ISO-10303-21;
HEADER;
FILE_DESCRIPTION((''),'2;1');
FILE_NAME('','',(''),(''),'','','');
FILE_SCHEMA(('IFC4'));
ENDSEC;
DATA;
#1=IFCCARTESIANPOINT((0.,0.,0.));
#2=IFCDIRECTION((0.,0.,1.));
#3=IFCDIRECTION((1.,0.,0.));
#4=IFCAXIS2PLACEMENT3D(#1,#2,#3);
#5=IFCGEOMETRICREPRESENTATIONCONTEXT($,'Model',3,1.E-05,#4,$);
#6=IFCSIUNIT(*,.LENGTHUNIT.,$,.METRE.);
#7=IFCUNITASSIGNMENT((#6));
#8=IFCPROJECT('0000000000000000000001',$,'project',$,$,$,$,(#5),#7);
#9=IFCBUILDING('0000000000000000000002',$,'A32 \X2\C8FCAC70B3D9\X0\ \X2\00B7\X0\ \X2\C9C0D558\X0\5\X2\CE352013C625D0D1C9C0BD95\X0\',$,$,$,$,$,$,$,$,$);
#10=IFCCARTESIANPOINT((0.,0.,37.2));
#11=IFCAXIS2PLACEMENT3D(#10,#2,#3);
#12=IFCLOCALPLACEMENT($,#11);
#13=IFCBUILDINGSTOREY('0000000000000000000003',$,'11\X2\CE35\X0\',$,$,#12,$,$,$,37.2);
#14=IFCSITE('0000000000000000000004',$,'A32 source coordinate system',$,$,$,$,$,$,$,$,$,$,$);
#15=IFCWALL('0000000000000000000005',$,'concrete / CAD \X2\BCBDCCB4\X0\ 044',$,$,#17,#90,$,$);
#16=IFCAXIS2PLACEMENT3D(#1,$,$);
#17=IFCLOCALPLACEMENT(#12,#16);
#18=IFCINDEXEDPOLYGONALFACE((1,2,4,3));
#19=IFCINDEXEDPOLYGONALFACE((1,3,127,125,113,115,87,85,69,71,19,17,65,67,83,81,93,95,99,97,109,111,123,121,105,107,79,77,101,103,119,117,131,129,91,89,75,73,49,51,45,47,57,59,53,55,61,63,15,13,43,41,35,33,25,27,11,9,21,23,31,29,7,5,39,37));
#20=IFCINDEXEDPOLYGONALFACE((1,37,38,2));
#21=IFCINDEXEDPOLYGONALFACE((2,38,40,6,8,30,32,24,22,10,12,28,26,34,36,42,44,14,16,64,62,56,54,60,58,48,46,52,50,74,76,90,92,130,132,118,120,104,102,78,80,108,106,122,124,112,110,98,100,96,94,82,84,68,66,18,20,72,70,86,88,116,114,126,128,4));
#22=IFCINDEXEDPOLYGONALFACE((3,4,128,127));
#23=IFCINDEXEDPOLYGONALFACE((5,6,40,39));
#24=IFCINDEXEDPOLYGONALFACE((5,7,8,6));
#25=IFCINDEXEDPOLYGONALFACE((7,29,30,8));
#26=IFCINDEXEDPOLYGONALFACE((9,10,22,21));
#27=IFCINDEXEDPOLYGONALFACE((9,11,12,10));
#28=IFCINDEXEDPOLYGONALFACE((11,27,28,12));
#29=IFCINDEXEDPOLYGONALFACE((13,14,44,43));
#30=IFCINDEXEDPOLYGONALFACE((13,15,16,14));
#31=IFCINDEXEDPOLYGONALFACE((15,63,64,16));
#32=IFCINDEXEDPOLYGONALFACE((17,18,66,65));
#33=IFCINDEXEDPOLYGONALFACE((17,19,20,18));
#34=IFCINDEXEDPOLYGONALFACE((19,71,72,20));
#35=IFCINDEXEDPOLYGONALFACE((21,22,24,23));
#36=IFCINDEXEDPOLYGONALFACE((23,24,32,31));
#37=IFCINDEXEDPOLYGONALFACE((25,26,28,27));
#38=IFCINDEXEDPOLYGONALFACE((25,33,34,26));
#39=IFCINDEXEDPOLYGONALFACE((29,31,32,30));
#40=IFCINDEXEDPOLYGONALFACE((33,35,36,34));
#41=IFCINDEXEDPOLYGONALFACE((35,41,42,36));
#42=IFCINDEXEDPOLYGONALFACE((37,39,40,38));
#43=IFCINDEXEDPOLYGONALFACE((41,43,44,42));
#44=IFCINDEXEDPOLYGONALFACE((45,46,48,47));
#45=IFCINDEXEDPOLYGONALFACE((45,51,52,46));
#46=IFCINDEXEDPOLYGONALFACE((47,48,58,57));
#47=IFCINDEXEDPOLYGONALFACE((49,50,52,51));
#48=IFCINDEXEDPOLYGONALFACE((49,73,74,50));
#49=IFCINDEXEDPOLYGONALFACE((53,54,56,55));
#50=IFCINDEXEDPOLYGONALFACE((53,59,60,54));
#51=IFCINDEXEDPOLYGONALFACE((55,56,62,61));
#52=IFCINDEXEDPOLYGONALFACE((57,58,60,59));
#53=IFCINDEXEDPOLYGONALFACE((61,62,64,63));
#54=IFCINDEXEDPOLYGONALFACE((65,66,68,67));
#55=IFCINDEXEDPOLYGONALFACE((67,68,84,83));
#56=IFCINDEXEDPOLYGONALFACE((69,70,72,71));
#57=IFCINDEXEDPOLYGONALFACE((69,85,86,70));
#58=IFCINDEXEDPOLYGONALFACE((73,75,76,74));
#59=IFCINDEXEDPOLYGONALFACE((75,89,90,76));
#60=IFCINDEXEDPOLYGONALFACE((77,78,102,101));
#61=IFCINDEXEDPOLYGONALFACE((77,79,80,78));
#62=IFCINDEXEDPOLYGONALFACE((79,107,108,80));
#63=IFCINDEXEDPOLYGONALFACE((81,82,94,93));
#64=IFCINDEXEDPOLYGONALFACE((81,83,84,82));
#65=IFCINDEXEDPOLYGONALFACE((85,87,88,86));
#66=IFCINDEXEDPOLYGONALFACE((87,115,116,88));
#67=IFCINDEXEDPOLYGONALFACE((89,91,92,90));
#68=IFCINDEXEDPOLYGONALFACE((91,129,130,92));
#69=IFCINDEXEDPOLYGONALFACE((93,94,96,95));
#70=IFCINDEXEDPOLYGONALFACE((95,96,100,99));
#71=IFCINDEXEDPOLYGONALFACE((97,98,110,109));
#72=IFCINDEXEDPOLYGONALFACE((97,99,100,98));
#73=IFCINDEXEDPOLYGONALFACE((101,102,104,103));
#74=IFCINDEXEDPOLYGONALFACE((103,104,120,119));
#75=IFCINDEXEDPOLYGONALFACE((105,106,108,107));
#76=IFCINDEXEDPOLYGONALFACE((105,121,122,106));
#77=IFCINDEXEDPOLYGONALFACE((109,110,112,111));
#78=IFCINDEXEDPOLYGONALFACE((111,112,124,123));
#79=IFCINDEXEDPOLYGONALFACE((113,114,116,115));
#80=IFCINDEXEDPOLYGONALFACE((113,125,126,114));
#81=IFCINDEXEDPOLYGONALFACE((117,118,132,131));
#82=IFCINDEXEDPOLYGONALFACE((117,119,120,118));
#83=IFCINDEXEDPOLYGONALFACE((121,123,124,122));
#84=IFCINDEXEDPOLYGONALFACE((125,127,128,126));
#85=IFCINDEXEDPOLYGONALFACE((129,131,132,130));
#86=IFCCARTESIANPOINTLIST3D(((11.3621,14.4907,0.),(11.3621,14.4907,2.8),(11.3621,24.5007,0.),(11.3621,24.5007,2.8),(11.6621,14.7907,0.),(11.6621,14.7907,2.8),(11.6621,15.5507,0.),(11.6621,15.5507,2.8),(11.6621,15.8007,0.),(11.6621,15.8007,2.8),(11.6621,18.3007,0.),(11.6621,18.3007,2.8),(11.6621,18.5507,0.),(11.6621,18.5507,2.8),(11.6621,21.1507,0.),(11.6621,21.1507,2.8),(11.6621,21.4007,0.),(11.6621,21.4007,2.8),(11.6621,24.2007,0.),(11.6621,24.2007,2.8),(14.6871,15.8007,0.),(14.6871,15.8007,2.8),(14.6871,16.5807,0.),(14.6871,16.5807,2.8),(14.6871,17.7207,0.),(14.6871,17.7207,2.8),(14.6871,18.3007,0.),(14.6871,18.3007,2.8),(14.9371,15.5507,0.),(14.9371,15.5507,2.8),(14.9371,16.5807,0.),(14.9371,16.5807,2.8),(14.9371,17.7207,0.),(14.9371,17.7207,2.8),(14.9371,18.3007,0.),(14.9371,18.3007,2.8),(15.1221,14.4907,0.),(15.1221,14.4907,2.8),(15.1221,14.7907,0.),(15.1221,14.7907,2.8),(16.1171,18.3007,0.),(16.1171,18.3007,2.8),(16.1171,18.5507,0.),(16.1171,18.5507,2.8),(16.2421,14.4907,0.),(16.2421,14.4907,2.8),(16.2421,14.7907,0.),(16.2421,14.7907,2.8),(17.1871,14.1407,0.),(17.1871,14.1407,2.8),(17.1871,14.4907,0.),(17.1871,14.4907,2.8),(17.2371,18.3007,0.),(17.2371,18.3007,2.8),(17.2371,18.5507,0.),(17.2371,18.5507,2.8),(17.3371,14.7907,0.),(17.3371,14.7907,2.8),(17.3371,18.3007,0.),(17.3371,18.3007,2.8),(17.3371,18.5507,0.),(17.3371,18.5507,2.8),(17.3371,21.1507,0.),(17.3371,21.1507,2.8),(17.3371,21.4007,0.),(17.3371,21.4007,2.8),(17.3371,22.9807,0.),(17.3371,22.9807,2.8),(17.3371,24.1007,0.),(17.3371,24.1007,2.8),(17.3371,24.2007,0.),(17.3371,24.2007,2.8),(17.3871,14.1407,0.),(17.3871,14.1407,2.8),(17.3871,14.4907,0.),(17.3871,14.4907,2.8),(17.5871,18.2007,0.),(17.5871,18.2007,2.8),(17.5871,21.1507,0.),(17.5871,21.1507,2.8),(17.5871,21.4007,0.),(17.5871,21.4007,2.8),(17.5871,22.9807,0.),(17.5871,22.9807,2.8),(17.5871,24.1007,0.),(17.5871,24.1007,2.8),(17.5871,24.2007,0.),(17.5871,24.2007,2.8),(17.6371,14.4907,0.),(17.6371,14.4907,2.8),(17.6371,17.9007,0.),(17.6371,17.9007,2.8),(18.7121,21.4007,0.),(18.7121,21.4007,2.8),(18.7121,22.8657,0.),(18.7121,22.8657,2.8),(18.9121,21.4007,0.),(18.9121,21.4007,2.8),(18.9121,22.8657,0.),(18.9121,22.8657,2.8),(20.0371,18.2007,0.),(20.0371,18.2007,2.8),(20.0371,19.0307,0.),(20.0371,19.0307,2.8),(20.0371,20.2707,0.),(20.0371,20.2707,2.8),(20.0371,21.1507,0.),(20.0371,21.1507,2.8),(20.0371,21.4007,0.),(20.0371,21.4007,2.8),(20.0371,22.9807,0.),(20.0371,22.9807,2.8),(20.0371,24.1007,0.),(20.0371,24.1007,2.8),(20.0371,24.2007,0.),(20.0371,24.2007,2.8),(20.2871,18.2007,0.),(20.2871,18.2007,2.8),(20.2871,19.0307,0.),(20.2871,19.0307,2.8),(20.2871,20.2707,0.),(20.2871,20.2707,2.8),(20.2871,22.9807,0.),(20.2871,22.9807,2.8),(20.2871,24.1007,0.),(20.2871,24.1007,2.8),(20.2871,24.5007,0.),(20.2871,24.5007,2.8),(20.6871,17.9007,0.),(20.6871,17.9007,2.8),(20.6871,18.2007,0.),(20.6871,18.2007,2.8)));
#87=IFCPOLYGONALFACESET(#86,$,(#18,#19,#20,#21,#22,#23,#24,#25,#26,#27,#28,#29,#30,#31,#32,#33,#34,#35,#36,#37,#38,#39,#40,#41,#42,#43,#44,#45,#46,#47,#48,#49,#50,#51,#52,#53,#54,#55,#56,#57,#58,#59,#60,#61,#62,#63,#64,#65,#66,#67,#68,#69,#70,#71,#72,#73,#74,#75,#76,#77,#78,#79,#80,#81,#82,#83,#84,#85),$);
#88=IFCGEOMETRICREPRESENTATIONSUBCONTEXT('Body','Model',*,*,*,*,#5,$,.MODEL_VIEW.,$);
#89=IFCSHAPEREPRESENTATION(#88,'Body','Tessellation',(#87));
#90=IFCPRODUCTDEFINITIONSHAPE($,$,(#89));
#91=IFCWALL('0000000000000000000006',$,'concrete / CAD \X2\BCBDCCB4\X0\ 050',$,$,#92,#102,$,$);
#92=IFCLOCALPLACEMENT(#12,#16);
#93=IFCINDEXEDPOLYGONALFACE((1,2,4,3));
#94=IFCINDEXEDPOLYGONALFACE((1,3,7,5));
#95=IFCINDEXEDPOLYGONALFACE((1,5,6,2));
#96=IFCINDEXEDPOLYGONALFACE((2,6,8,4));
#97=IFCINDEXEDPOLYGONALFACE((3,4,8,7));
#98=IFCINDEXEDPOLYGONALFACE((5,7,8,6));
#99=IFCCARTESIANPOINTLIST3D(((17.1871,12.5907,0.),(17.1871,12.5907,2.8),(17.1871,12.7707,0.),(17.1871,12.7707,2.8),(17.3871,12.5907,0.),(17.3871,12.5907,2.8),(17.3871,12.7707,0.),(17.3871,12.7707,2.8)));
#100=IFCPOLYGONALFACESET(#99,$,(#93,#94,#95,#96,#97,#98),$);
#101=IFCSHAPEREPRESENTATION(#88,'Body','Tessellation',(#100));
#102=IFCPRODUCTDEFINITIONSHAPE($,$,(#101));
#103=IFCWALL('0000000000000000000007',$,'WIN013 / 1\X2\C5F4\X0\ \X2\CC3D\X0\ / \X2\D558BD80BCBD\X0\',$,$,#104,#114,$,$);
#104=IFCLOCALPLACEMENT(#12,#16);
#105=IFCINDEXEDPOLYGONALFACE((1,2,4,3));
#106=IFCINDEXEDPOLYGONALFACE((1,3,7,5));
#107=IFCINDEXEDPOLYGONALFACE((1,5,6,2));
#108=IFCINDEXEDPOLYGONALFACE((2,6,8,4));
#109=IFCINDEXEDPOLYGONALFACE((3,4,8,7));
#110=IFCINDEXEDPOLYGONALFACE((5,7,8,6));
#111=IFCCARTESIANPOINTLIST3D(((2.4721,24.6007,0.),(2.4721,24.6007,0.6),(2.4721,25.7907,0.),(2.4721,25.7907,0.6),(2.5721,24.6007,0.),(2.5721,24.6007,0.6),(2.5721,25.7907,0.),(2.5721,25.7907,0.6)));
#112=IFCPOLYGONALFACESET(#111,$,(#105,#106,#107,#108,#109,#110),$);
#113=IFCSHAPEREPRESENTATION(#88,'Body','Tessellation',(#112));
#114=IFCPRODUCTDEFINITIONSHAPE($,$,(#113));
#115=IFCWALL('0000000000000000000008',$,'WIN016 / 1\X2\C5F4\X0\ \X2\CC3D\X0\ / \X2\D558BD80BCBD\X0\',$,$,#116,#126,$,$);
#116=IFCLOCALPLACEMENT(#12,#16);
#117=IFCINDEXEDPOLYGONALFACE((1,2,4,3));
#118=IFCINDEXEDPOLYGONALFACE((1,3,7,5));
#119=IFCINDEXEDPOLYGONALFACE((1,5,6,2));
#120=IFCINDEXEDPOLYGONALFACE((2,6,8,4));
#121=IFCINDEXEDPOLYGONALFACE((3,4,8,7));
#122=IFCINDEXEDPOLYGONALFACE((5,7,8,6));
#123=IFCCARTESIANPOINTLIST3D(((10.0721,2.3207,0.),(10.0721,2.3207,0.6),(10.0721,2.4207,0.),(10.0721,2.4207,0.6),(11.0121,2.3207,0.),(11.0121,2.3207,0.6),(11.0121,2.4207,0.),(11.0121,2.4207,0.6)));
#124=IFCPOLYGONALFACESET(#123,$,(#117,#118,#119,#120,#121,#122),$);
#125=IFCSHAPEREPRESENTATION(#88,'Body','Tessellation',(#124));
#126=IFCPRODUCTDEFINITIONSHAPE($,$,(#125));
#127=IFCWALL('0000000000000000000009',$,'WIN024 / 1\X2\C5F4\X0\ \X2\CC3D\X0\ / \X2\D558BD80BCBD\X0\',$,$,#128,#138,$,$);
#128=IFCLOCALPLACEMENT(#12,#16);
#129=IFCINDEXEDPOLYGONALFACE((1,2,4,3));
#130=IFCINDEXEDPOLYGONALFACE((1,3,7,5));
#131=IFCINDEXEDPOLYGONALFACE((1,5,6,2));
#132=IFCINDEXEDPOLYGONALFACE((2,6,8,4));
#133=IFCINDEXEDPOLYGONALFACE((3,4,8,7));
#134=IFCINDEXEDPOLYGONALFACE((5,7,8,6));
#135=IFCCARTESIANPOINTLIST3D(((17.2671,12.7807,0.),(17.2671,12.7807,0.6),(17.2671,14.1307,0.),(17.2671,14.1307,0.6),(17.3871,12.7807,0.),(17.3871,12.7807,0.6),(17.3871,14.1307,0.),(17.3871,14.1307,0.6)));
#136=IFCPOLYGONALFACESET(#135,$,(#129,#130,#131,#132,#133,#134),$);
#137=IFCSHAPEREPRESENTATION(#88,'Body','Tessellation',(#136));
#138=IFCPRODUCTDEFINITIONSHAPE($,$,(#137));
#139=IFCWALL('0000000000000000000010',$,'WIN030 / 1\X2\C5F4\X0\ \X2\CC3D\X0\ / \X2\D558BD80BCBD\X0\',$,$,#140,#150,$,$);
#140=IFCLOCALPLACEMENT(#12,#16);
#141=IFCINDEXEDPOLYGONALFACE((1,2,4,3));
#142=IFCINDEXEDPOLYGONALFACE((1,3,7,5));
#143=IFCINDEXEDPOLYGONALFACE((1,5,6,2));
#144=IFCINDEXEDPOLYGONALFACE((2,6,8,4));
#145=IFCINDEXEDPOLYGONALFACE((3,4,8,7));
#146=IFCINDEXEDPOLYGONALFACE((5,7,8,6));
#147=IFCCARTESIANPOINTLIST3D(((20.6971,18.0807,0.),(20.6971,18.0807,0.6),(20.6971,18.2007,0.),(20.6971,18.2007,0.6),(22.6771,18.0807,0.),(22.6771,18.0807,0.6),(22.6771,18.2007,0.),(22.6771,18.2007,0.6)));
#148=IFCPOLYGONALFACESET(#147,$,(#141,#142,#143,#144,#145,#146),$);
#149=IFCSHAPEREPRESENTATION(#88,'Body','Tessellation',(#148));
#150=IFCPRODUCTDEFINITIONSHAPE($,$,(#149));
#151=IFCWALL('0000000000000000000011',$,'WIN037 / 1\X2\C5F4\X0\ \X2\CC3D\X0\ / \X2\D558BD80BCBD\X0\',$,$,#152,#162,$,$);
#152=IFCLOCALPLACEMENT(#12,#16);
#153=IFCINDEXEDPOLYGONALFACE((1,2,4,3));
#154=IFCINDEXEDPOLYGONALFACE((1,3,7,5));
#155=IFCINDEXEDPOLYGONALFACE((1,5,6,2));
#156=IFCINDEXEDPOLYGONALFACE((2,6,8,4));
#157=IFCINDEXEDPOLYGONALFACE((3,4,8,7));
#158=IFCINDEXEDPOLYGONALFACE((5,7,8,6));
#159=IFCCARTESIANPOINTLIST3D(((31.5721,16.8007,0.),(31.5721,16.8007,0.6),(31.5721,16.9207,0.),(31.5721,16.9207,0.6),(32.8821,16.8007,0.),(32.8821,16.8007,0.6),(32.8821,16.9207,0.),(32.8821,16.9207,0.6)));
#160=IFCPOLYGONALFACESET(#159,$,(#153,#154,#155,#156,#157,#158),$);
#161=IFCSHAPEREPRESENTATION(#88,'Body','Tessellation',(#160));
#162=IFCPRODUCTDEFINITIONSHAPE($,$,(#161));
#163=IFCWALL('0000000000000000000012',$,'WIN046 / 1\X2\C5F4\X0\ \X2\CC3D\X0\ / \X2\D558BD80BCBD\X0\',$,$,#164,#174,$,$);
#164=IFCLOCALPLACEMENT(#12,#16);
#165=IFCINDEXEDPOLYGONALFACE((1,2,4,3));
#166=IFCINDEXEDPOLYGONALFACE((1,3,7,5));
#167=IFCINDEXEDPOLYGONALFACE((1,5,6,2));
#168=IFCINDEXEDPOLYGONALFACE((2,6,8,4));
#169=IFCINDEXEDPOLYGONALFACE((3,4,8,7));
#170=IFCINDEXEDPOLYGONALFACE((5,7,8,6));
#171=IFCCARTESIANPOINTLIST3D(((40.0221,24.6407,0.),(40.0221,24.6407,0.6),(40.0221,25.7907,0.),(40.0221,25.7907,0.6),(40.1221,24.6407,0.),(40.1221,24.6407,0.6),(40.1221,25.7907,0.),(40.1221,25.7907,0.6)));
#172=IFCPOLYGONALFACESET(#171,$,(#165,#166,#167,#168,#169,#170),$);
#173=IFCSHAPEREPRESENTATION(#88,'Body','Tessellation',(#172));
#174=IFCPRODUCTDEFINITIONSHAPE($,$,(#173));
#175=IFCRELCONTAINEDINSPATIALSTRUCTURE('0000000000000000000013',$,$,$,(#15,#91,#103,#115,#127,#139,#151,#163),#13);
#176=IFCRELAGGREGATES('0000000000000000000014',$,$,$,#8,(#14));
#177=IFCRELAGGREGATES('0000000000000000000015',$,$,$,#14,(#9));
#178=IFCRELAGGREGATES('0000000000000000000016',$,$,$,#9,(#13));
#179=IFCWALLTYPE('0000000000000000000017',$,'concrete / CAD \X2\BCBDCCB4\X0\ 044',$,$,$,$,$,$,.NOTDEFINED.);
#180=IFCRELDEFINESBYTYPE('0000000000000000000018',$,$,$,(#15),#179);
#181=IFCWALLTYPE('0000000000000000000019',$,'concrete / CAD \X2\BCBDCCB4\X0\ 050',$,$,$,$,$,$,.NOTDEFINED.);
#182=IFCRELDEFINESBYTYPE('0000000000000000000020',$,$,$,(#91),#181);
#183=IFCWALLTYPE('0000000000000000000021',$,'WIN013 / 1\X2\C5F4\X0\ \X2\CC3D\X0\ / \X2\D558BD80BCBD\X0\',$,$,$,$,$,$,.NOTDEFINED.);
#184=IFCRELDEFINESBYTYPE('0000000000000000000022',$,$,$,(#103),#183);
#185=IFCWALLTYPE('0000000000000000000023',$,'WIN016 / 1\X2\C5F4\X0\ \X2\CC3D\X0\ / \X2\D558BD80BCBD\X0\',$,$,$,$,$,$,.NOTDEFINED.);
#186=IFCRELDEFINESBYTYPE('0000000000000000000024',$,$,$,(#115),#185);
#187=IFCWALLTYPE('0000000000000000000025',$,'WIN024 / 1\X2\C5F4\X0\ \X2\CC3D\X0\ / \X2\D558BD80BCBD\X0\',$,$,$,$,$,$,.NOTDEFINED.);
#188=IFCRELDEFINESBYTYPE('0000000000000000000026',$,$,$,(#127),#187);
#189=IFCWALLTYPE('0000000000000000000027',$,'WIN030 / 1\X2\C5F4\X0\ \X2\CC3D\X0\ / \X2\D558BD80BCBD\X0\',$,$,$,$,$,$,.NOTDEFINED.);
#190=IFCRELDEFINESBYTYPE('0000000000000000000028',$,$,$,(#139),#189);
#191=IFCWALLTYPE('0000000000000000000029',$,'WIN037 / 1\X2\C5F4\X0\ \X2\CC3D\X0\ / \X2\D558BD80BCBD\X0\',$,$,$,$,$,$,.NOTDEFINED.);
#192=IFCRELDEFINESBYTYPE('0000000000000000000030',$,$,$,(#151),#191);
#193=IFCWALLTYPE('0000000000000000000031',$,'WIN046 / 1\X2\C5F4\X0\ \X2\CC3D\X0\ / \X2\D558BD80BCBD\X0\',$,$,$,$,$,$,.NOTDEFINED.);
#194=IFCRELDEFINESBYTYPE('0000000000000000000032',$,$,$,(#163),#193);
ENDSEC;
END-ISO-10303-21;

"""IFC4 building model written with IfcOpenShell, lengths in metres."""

from ifc_helpers import new_model, si_unit, frame, origin, origin_with_axes, place, context, subcontext, project, spatial, polyline, outline, extrude, source, transform, mapped, type_object, type_shapes, element, save


model = new_model("IFC4")

# Units and contexts
model_context = context("Model", 3, precision=1e-05, world=origin_with_axes())
body_context = subcontext(model_context, "Body", "Model", "MODEL_VIEW")
ifc_project = project(units=[si_unit("LENGTHUNIT", "METRE")], contexts=[model_context])

# Site, building, storey
site = spatial("IfcSite", under=ifc_project, Name="A32 source coordinate system")
building = spatial("IfcBuilding", under=site, Name="A32 주거동 · 지하5층–옥탑지붕")
storey_placement = place(None, frame((0.0, 0.0, 37.2), z_axis=(0.0, 0.0, 1.0), x_axis=(1.0, 0.0, 0.0)))
storey = spatial("IfcBuildingStorey", under=building, at=storey_placement, Name="11층", Elevation=37.2)

# Walls
wall_type_1 = type_object("IfcWallType", Name="concrete / CAD 벽체 044", PredefinedType="NOTDEFINED")
shared_shape_1 = source(origin(), body_context, "Body", "SweptSolid", [
    extrude(outline(polyline([(17.3371, 21.4007), (17.3371, 22.9807), (17.5871, 22.9807), (17.5871, 21.4007), (18.7121, 21.4007), (18.7121, 22.8657), (18.9121, 22.8657), (18.9121, 21.4007), (20.0371, 21.4007), (20.0371, 22.9807), (20.2871, 22.9807), (20.2871, 20.2707), (20.0371, 20.2707), (20.0371, 21.1507), (17.5871, 21.1507), (17.5871, 18.2007), (20.0371, 18.2007), (20.0371, 19.0307), (20.2871, 19.0307), (20.2871, 18.2007), (20.6871, 18.2007), (20.6871, 17.9007), (17.6371, 17.9007), (17.6371, 14.4907), (17.3871, 14.4907), (17.3871, 14.1407), (17.1871, 14.1407), (17.1871, 14.4907), (16.2421, 14.4907), (16.2421, 14.7907), (17.3371, 14.7907), (17.3371, 18.3007), (17.2371, 18.3007), (17.2371, 18.5507), (17.3371, 18.5507), (17.3371, 21.1507), (11.6621, 21.1507), (11.6621, 18.5507), (16.1171, 18.5507), (16.1171, 18.3007), (14.9371, 18.3007), (14.9371, 17.7207), (14.6871, 17.7207), (14.6871, 18.3007), (11.6621, 18.3007), (11.6621, 15.8007), (14.6871, 15.8007), (14.6871, 16.5807), (14.9371, 16.5807), (14.9371, 15.5507), (11.6621, 15.5507), (11.6621, 14.7907), (15.1221, 14.7907), (15.1221, 14.4907), (11.3621, 14.4907), (11.3621, 24.5007), (20.2871, 24.5007), (20.2871, 24.1007), (20.0371, 24.1007), (20.0371, 24.2007), (17.5871, 24.2007), (17.5871, 24.1007), (17.3371, 24.1007), (17.3371, 24.2007), (11.6621, 24.2007), (11.6621, 21.4007), (17.3371, 21.4007)])), origin(), (0.0, 0.0, 1.0), 2.8),
])
type_shapes(wall_type_1, [shared_shape_1])
wall_1_placement = place(storey_placement, origin_with_axes())
element("IfcWall", 1, at=wall_1_placement, inside=storey, type_object=wall_type_1, Name="concrete / CAD 벽체 044", context=body_context, shape_type="MappedRepresentation", body=[
    mapped(shared_shape_1, transform((0.0, 0.0, 0.0), scale=1.0)),
])
wall_type_2 = type_object("IfcWallType", Name="concrete / CAD 벽체 050", PredefinedType="NOTDEFINED")
shared_shape_2 = source(origin(), body_context, "Body", "SweptSolid", [
    extrude(outline(polyline([(17.3871, 12.5907), (17.1871, 12.5907), (17.1871, 12.7707), (17.3871, 12.7707), (17.3871, 12.5907)])), origin(), (0.0, 0.0, 1.0), 2.8),
])
type_shapes(wall_type_2, [shared_shape_2])
wall_2_placement = place(storey_placement, origin_with_axes())
element("IfcWall", 2, at=wall_2_placement, inside=storey, type_object=wall_type_2, Name="concrete / CAD 벽체 050", context=body_context, shape_type="MappedRepresentation", body=[
    mapped(shared_shape_2, transform((0.0, 0.0, 0.0), scale=1.0)),
])
wall_type_3 = type_object("IfcWallType", Name="WIN013 / 1열 창 / 하부벽", PredefinedType="NOTDEFINED")
shared_shape_3 = source(origin(), body_context, "Body", "SweptSolid", [
    extrude(outline(polyline([(2.5721, 25.7907), (2.5721, 24.6007), (2.4721, 24.6007), (2.4721, 25.7907), (2.5721, 25.7907)])), origin(), (0.0, 0.0, 1.0), 0.6),
])
type_shapes(wall_type_3, [shared_shape_3])
wall_3_placement = place(storey_placement, origin_with_axes())
element("IfcWall", 3, at=wall_3_placement, inside=storey, type_object=wall_type_3, Name="WIN013 / 1열 창 / 하부벽", context=body_context, shape_type="MappedRepresentation", body=[
    mapped(shared_shape_3, transform((0.0, 0.0, 0.0), scale=1.0)),
])
wall_type_4 = type_object("IfcWallType", Name="WIN016 / 1열 창 / 하부벽", PredefinedType="NOTDEFINED")
shared_shape_4 = source(origin(), body_context, "Body", "SweptSolid", [
    extrude(outline(polyline([(11.0121, 2.4207), (11.0121, 2.3207), (10.0721, 2.3207), (10.0721, 2.4207), (11.0121, 2.4207)])), origin(), (0.0, 0.0, 1.0), 0.6),
])
type_shapes(wall_type_4, [shared_shape_4])
wall_4_placement = place(storey_placement, origin_with_axes())
element("IfcWall", 4, at=wall_4_placement, inside=storey, type_object=wall_type_4, Name="WIN016 / 1열 창 / 하부벽", context=body_context, shape_type="MappedRepresentation", body=[
    mapped(shared_shape_4, transform((0.0, 0.0, 0.0), scale=1.0)),
])
wall_type_5 = type_object("IfcWallType", Name="WIN024 / 1열 창 / 하부벽", PredefinedType="NOTDEFINED")
shared_shape_5 = source(origin(), body_context, "Body", "SweptSolid", [
    extrude(outline(polyline([(17.3871, 14.1307), (17.3871, 12.7807), (17.2671, 12.7807), (17.2671, 14.1307), (17.3871, 14.1307)])), origin(), (0.0, 0.0, 1.0), 0.6),
])
type_shapes(wall_type_5, [shared_shape_5])
wall_5_placement = place(storey_placement, origin_with_axes())
element("IfcWall", 5, at=wall_5_placement, inside=storey, type_object=wall_type_5, Name="WIN024 / 1열 창 / 하부벽", context=body_context, shape_type="MappedRepresentation", body=[
    mapped(shared_shape_5, transform((0.0, 0.0, 0.0), scale=1.0)),
])
wall_type_6 = type_object("IfcWallType", Name="WIN030 / 1열 창 / 하부벽", PredefinedType="NOTDEFINED")
shared_shape_6 = source(origin(), body_context, "Body", "SweptSolid", [
    extrude(outline(polyline([(22.6771, 18.2007), (22.6771, 18.0807), (20.6971, 18.0807), (20.6971, 18.2007), (22.6771, 18.2007)])), origin(), (0.0, 0.0, 1.0), 0.6),
])
type_shapes(wall_type_6, [shared_shape_6])
wall_6_placement = place(storey_placement, origin_with_axes())
element("IfcWall", 6, at=wall_6_placement, inside=storey, type_object=wall_type_6, Name="WIN030 / 1열 창 / 하부벽", context=body_context, shape_type="MappedRepresentation", body=[
    mapped(shared_shape_6, transform((0.0, 0.0, 0.0), scale=1.0)),
])
wall_type_7 = type_object("IfcWallType", Name="WIN037 / 1열 창 / 하부벽", PredefinedType="NOTDEFINED")
shared_shape_7 = source(origin(), body_context, "Body", "SweptSolid", [
    extrude(outline(polyline([(32.8821, 16.9207), (32.8821, 16.8007), (31.5721, 16.8007), (31.5721, 16.9207), (32.8821, 16.9207)])), origin(), (0.0, 0.0, 1.0), 0.6),
])
type_shapes(wall_type_7, [shared_shape_7])
wall_7_placement = place(storey_placement, origin_with_axes())
element("IfcWall", 7, at=wall_7_placement, inside=storey, type_object=wall_type_7, Name="WIN037 / 1열 창 / 하부벽", context=body_context, shape_type="MappedRepresentation", body=[
    mapped(shared_shape_7, transform((0.0, 0.0, 0.0), scale=1.0)),
])
wall_type_8 = type_object("IfcWallType", Name="WIN046 / 1열 창 / 하부벽", PredefinedType="NOTDEFINED")
shared_shape_8 = source(origin(), body_context, "Body", "SweptSolid", [
    extrude(outline(polyline([(40.1221, 25.7907), (40.1221, 24.6407), (40.0221, 24.6407), (40.0221, 25.7907), (40.1221, 25.7907)])), origin(), (0.0, 0.0, 1.0), 0.6),
])
type_shapes(wall_type_8, [shared_shape_8])
wall_8_placement = place(storey_placement, origin_with_axes())
element("IfcWall", 8, at=wall_8_placement, inside=storey, type_object=wall_type_8, Name="WIN046 / 1열 창 / 하부벽", context=body_context, shape_type="MappedRepresentation", body=[
    mapped(shared_shape_8, transform((0.0, 0.0, 0.0), scale=1.0)),
])

save(model, "model.ifc")
